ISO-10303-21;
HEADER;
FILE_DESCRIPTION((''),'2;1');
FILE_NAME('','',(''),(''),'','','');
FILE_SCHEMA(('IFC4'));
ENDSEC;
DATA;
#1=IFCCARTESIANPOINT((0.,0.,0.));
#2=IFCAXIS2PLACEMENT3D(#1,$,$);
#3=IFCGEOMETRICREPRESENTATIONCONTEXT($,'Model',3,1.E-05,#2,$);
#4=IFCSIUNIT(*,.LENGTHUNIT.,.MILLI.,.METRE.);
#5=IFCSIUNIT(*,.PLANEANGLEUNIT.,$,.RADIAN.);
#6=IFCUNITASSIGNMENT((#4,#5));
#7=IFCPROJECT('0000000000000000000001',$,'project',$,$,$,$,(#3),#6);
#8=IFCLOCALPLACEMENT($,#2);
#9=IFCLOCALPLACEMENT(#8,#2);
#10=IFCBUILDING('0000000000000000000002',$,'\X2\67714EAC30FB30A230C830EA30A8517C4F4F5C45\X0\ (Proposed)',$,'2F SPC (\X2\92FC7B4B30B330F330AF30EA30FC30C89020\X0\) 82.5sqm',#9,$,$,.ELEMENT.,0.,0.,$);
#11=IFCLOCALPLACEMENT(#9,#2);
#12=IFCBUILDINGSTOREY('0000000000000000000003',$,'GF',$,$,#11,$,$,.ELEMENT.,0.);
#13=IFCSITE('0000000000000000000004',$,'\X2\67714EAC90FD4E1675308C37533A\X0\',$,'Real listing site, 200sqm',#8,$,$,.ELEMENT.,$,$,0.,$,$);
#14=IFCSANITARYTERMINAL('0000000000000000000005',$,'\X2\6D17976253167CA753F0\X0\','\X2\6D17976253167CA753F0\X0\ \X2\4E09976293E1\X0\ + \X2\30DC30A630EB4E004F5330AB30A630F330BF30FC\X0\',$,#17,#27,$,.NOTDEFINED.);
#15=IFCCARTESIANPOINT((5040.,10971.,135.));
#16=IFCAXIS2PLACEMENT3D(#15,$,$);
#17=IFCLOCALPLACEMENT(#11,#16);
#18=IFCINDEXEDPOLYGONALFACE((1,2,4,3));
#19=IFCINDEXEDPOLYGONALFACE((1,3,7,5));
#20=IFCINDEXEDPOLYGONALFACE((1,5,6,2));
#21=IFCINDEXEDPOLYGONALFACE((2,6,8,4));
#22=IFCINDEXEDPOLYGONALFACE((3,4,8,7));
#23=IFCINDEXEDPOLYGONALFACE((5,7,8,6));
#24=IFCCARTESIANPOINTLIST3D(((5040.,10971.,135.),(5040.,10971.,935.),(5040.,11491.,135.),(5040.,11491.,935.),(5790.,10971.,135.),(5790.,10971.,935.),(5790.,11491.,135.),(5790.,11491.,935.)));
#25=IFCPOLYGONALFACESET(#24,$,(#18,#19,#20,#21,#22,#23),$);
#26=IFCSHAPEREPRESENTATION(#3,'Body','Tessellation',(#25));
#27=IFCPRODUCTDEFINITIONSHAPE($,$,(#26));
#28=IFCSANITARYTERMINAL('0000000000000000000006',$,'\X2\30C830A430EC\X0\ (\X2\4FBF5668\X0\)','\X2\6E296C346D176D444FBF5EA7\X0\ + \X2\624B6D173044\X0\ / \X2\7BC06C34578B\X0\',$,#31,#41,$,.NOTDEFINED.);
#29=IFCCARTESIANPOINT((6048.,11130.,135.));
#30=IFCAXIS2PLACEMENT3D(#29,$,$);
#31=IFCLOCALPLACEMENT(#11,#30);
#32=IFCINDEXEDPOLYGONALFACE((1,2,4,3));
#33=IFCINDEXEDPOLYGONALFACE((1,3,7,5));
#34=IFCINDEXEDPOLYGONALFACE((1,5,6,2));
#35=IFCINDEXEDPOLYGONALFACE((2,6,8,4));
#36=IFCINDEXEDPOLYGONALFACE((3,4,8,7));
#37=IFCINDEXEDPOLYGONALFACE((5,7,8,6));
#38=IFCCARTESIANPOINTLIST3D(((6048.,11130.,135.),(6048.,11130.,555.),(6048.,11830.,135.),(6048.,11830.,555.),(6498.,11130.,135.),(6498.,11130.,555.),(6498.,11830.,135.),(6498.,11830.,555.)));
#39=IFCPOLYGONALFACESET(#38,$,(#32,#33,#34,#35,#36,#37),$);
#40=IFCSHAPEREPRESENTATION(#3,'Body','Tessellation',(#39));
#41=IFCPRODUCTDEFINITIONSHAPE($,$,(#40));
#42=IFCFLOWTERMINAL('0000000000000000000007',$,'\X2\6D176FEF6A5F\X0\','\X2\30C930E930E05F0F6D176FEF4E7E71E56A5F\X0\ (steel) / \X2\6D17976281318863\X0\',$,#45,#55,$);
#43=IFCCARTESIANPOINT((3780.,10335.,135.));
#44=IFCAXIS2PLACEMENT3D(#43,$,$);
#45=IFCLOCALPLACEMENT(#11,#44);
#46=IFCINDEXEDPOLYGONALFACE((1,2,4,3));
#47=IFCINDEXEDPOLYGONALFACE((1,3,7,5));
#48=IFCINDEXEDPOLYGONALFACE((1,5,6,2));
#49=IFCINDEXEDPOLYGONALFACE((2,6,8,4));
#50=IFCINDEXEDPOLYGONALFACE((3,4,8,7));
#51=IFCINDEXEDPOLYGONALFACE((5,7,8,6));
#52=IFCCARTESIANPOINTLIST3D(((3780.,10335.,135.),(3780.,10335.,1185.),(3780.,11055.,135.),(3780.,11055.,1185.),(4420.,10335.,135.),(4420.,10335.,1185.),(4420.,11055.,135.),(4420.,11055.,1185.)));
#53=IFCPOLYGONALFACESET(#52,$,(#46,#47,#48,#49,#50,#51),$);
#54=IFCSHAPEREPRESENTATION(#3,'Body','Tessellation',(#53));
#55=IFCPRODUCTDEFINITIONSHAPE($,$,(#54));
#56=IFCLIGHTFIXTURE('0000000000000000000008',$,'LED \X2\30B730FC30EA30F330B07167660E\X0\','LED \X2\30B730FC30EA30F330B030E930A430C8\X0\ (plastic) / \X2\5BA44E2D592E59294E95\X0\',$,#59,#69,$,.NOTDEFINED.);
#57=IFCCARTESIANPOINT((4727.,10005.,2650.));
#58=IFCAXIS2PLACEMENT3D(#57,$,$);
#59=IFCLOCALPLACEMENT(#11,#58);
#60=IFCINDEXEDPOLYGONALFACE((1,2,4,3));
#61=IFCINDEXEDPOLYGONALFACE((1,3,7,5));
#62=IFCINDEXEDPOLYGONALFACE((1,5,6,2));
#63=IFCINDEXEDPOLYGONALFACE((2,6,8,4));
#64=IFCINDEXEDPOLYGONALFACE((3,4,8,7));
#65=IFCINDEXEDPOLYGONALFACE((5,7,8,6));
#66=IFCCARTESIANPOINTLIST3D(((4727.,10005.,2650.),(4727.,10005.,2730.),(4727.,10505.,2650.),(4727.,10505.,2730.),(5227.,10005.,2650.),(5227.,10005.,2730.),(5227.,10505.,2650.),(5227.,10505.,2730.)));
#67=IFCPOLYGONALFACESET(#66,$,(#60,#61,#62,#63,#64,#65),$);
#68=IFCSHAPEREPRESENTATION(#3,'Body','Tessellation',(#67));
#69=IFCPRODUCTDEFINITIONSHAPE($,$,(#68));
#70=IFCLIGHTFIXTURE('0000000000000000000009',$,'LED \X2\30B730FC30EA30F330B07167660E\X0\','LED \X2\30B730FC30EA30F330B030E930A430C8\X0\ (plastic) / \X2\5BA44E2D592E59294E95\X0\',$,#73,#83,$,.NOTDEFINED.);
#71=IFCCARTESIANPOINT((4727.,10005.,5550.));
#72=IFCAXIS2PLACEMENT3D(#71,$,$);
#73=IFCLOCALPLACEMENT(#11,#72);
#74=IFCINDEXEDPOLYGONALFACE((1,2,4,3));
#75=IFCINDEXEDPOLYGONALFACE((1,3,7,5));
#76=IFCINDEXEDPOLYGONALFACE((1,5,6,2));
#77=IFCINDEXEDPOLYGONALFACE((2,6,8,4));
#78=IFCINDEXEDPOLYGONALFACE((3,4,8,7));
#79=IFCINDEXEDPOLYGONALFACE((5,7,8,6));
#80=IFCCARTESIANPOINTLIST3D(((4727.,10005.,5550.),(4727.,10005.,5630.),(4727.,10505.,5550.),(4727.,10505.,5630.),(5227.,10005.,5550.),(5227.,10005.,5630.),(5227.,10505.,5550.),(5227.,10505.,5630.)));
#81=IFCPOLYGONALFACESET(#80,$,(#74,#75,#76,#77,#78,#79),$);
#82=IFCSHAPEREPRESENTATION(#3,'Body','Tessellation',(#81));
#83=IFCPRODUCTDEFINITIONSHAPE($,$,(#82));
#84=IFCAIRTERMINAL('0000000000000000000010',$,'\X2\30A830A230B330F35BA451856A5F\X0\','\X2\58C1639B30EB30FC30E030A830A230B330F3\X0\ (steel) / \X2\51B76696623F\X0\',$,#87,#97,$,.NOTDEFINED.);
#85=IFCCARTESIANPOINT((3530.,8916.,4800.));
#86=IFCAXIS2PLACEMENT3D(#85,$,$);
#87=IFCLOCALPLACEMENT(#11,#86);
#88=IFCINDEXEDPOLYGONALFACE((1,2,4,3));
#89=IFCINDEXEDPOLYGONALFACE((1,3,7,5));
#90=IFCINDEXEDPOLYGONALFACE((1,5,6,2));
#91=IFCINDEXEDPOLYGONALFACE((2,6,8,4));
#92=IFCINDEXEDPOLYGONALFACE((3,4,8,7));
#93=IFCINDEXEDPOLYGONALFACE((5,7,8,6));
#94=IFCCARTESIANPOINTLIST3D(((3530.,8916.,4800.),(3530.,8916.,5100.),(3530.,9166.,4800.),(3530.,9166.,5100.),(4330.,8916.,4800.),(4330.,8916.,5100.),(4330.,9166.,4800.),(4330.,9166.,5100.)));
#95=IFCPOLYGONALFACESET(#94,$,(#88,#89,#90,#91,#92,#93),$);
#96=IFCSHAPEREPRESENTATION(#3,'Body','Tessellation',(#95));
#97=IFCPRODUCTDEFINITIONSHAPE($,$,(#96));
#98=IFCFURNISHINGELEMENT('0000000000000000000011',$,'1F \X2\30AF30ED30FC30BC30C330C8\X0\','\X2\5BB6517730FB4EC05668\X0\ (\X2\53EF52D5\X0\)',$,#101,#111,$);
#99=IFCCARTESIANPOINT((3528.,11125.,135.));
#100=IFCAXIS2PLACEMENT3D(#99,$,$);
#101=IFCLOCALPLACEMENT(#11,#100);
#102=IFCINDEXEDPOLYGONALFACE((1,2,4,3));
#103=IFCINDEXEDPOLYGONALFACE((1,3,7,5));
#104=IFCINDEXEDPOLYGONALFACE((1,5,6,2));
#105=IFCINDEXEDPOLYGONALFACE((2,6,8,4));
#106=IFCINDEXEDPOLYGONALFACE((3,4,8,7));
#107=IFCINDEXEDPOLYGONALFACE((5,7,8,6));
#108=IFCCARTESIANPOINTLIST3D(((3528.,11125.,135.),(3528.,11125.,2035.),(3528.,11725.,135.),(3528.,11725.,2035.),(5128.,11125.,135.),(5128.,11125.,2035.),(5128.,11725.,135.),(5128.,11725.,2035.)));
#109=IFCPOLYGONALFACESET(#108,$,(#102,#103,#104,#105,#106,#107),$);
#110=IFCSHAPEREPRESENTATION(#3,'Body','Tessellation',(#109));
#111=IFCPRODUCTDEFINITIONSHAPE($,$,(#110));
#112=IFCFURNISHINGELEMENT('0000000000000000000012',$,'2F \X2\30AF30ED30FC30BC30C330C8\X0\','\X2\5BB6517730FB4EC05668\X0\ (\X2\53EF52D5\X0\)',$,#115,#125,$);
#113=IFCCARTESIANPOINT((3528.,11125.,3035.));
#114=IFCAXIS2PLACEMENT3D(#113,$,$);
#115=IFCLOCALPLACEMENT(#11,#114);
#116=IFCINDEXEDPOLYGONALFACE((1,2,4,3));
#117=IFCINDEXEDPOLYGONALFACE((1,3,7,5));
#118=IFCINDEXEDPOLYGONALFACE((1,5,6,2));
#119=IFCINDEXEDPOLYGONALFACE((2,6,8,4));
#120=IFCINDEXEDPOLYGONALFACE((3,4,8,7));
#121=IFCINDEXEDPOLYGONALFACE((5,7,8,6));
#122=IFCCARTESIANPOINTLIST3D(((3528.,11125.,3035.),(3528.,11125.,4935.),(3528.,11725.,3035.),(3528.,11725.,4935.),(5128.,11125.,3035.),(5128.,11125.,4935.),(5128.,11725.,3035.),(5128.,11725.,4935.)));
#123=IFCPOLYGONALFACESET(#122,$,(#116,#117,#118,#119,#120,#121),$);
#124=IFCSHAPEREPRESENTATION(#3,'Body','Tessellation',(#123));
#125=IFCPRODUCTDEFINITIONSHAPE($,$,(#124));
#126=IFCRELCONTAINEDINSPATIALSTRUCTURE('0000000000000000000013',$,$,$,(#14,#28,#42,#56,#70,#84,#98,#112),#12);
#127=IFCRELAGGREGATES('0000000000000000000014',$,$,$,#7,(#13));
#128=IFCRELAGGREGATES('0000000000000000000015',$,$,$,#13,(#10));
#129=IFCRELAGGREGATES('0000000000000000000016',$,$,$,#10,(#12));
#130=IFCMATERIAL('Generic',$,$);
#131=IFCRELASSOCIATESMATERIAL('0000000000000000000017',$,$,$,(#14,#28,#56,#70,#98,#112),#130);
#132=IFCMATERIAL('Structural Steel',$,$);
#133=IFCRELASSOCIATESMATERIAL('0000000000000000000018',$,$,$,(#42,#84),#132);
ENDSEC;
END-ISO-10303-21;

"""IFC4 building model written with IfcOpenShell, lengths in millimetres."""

from ifc_helpers import new_model, si_unit, frame, frame_2d, origin, place, context, project, spatial, rectangle, extrude, material, element, save


model = new_model("IFC4")

# Units and contexts
model_context = context("Model", 3, precision=1e-05, world=origin())
ifc_project = project(units=[si_unit("LENGTHUNIT", "METRE", prefix="MILLI"), si_unit("PLANEANGLEUNIT", "RADIAN")], contexts=[model_context])

# Site, building, storey
site_placement = place(None, origin())
site = spatial("IfcSite", under=ifc_project, at=site_placement, Name="東京都世田谷区", ObjectType="Real listing site, 200sqm", CompositionType="ELEMENT", RefElevation=0.0)
building_placement = place(site_placement, origin())
building = spatial("IfcBuilding", under=site, at=building_placement, Name="東京・アトリエ兼住居 (Proposed)", ObjectType="2F SPC (鋼筋コンクリート造) 82.5sqm", CompositionType="ELEMENT", ElevationOfRefHeight=0.0, ElevationOfTerrain=0.0)
storey_placement = place(building_placement, origin())
storey = spatial("IfcBuildingStorey", under=building, at=storey_placement, Name="GF", CompositionType="ELEMENT", Elevation=0.0)

# Sanitary terminals
ifc_material_1 = material(Name="Generic")
sanitary_terminal_1_placement = place(storey_placement, frame((5040.0, 10971.0, 135.0)))
element("IfcSanitaryTerminal", 1, at=sanitary_terminal_1_placement, inside=storey, material=ifc_material_1, Name="洗面化粧台", Description="洗面化粧台 三面鏡 + ボウル一体カウンター", PredefinedType="NOTDEFINED", context=model_context, shape_type="SweptSolid", body=[
    extrude(rectangle(XDim=750.0, YDim=520.0, at=frame_2d((375.0, 260.0))), frame((5040.0, 10971.0, 135.0)), (0.0, 0.0, 1.0), 800.0),
])
sanitary_terminal_2_placement = place(storey_placement, frame((6048.0, 11130.0, 135.0)))
element("IfcSanitaryTerminal", 2, at=sanitary_terminal_2_placement, inside=storey, material=ifc_material_1, Name="トイレ (便器)", Description="温水洗浄便座 + 手洗い / 節水型", PredefinedType="NOTDEFINED", context=model_context, shape_type="SweptSolid", body=[
    extrude(rectangle(XDim=450.0, YDim=700.0, at=frame_2d((225.0, 350.0))), frame((6048.0, 11130.0, 135.0)), (0.0, 0.0, 1.0), 420.0),
])

# Flow terminal
ifc_material_2 = material(Name="Structural Steel")
flow_terminal_placement = place(storey_placement, frame((3780.0, 10335.0, 135.0)))
element("IfcFlowTerminal", 3, at=flow_terminal_placement, inside=storey, material=ifc_material_2, Name="洗濯機", Description="ドラム式洗濯乾燥機 (steel) / 洗面脱衣", context=model_context, shape_type="SweptSolid", body=[
    extrude(rectangle(XDim=640.0, YDim=720.0, at=frame_2d((320.0, 360.0))), frame((3780.0, 10335.0, 135.0)), (0.0, 0.0, 1.0), 1050.0),
])

# Light fixtures
light_fixture_1_placement = place(storey_placement, frame((4727.0, 10005.0, 2650.0)))
element("IfcLightFixture", 4, at=light_fixture_1_placement, inside=storey, material=ifc_material_1, Name="LED シーリング照明", Description="LED シーリングライト (plastic) / 室中央天井", PredefinedType="NOTDEFINED", context=model_context, shape_type="SweptSolid", body=[
    extrude(rectangle(XDim=500.0, YDim=500.0, at=frame_2d((250.0, 250.0))), frame((4727.0, 10005.0, 2650.0)), (0.0, 0.0, 1.0), 80.0),
])
light_fixture_2_placement = place(storey_placement, frame((4727.0, 10005.0, 5550.0)))
element("IfcLightFixture", 5, at=light_fixture_2_placement, inside=storey, material=ifc_material_1, Name="LED シーリング照明", Description="LED シーリングライト (plastic) / 室中央天井", PredefinedType="NOTDEFINED", context=model_context, shape_type="SweptSolid", body=[
    extrude(rectangle(XDim=500.0, YDim=500.0, at=frame_2d((250.0, 250.0))), frame((4727.0, 10005.0, 5550.0)), (0.0, 0.0, 1.0), 80.0),
])

# Air terminal
air_terminal_placement = place(storey_placement, frame((3530.0, 8916.0, 4800.0)))
element("IfcAirTerminal", 6, at=air_terminal_placement, inside=storey, material=ifc_material_2, Name="エアコン室内機", Description="壁掛ルームエアコン (steel) / 冷暖房", PredefinedType="NOTDEFINED", context=model_context, shape_type="SweptSolid", body=[
    extrude(rectangle(XDim=800.0, YDim=250.0, at=frame_2d((400.0, 125.0))), frame((3530.0, 8916.0, 4800.0)), (0.0, 0.0, 1.0), 300.0),
])

# Furnishing elements
furnishing_1_placement = place(storey_placement, frame((3528.0, 11125.0, 135.0)))
element("IfcFurnishingElement", 7, at=furnishing_1_placement, inside=storey, material=ifc_material_1, Name="1F クローゼット", Description="家具・什器 (可動)", context=model_context, shape_type="SweptSolid", body=[
    extrude(rectangle(XDim=1600.0, YDim=600.0, at=frame_2d((800.0, 300.0))), frame((3528.0, 11125.0, 135.0)), (0.0, 0.0, 1.0), 1900.0),
])
furnishing_2_placement = place(storey_placement, frame((3528.0, 11125.0, 3035.0)))
element("IfcFurnishingElement", 8, at=furnishing_2_placement, inside=storey, material=ifc_material_1, Name="2F クローゼット", Description="家具・什器 (可動)", context=model_context, shape_type="SweptSolid", body=[
    extrude(rectangle(XDim=1600.0, YDim=600.0, at=frame_2d((800.0, 300.0))), frame((3528.0, 11125.0, 3035.0)), (0.0, 0.0, 1.0), 1900.0),
])

save(model, "model.ifc")
